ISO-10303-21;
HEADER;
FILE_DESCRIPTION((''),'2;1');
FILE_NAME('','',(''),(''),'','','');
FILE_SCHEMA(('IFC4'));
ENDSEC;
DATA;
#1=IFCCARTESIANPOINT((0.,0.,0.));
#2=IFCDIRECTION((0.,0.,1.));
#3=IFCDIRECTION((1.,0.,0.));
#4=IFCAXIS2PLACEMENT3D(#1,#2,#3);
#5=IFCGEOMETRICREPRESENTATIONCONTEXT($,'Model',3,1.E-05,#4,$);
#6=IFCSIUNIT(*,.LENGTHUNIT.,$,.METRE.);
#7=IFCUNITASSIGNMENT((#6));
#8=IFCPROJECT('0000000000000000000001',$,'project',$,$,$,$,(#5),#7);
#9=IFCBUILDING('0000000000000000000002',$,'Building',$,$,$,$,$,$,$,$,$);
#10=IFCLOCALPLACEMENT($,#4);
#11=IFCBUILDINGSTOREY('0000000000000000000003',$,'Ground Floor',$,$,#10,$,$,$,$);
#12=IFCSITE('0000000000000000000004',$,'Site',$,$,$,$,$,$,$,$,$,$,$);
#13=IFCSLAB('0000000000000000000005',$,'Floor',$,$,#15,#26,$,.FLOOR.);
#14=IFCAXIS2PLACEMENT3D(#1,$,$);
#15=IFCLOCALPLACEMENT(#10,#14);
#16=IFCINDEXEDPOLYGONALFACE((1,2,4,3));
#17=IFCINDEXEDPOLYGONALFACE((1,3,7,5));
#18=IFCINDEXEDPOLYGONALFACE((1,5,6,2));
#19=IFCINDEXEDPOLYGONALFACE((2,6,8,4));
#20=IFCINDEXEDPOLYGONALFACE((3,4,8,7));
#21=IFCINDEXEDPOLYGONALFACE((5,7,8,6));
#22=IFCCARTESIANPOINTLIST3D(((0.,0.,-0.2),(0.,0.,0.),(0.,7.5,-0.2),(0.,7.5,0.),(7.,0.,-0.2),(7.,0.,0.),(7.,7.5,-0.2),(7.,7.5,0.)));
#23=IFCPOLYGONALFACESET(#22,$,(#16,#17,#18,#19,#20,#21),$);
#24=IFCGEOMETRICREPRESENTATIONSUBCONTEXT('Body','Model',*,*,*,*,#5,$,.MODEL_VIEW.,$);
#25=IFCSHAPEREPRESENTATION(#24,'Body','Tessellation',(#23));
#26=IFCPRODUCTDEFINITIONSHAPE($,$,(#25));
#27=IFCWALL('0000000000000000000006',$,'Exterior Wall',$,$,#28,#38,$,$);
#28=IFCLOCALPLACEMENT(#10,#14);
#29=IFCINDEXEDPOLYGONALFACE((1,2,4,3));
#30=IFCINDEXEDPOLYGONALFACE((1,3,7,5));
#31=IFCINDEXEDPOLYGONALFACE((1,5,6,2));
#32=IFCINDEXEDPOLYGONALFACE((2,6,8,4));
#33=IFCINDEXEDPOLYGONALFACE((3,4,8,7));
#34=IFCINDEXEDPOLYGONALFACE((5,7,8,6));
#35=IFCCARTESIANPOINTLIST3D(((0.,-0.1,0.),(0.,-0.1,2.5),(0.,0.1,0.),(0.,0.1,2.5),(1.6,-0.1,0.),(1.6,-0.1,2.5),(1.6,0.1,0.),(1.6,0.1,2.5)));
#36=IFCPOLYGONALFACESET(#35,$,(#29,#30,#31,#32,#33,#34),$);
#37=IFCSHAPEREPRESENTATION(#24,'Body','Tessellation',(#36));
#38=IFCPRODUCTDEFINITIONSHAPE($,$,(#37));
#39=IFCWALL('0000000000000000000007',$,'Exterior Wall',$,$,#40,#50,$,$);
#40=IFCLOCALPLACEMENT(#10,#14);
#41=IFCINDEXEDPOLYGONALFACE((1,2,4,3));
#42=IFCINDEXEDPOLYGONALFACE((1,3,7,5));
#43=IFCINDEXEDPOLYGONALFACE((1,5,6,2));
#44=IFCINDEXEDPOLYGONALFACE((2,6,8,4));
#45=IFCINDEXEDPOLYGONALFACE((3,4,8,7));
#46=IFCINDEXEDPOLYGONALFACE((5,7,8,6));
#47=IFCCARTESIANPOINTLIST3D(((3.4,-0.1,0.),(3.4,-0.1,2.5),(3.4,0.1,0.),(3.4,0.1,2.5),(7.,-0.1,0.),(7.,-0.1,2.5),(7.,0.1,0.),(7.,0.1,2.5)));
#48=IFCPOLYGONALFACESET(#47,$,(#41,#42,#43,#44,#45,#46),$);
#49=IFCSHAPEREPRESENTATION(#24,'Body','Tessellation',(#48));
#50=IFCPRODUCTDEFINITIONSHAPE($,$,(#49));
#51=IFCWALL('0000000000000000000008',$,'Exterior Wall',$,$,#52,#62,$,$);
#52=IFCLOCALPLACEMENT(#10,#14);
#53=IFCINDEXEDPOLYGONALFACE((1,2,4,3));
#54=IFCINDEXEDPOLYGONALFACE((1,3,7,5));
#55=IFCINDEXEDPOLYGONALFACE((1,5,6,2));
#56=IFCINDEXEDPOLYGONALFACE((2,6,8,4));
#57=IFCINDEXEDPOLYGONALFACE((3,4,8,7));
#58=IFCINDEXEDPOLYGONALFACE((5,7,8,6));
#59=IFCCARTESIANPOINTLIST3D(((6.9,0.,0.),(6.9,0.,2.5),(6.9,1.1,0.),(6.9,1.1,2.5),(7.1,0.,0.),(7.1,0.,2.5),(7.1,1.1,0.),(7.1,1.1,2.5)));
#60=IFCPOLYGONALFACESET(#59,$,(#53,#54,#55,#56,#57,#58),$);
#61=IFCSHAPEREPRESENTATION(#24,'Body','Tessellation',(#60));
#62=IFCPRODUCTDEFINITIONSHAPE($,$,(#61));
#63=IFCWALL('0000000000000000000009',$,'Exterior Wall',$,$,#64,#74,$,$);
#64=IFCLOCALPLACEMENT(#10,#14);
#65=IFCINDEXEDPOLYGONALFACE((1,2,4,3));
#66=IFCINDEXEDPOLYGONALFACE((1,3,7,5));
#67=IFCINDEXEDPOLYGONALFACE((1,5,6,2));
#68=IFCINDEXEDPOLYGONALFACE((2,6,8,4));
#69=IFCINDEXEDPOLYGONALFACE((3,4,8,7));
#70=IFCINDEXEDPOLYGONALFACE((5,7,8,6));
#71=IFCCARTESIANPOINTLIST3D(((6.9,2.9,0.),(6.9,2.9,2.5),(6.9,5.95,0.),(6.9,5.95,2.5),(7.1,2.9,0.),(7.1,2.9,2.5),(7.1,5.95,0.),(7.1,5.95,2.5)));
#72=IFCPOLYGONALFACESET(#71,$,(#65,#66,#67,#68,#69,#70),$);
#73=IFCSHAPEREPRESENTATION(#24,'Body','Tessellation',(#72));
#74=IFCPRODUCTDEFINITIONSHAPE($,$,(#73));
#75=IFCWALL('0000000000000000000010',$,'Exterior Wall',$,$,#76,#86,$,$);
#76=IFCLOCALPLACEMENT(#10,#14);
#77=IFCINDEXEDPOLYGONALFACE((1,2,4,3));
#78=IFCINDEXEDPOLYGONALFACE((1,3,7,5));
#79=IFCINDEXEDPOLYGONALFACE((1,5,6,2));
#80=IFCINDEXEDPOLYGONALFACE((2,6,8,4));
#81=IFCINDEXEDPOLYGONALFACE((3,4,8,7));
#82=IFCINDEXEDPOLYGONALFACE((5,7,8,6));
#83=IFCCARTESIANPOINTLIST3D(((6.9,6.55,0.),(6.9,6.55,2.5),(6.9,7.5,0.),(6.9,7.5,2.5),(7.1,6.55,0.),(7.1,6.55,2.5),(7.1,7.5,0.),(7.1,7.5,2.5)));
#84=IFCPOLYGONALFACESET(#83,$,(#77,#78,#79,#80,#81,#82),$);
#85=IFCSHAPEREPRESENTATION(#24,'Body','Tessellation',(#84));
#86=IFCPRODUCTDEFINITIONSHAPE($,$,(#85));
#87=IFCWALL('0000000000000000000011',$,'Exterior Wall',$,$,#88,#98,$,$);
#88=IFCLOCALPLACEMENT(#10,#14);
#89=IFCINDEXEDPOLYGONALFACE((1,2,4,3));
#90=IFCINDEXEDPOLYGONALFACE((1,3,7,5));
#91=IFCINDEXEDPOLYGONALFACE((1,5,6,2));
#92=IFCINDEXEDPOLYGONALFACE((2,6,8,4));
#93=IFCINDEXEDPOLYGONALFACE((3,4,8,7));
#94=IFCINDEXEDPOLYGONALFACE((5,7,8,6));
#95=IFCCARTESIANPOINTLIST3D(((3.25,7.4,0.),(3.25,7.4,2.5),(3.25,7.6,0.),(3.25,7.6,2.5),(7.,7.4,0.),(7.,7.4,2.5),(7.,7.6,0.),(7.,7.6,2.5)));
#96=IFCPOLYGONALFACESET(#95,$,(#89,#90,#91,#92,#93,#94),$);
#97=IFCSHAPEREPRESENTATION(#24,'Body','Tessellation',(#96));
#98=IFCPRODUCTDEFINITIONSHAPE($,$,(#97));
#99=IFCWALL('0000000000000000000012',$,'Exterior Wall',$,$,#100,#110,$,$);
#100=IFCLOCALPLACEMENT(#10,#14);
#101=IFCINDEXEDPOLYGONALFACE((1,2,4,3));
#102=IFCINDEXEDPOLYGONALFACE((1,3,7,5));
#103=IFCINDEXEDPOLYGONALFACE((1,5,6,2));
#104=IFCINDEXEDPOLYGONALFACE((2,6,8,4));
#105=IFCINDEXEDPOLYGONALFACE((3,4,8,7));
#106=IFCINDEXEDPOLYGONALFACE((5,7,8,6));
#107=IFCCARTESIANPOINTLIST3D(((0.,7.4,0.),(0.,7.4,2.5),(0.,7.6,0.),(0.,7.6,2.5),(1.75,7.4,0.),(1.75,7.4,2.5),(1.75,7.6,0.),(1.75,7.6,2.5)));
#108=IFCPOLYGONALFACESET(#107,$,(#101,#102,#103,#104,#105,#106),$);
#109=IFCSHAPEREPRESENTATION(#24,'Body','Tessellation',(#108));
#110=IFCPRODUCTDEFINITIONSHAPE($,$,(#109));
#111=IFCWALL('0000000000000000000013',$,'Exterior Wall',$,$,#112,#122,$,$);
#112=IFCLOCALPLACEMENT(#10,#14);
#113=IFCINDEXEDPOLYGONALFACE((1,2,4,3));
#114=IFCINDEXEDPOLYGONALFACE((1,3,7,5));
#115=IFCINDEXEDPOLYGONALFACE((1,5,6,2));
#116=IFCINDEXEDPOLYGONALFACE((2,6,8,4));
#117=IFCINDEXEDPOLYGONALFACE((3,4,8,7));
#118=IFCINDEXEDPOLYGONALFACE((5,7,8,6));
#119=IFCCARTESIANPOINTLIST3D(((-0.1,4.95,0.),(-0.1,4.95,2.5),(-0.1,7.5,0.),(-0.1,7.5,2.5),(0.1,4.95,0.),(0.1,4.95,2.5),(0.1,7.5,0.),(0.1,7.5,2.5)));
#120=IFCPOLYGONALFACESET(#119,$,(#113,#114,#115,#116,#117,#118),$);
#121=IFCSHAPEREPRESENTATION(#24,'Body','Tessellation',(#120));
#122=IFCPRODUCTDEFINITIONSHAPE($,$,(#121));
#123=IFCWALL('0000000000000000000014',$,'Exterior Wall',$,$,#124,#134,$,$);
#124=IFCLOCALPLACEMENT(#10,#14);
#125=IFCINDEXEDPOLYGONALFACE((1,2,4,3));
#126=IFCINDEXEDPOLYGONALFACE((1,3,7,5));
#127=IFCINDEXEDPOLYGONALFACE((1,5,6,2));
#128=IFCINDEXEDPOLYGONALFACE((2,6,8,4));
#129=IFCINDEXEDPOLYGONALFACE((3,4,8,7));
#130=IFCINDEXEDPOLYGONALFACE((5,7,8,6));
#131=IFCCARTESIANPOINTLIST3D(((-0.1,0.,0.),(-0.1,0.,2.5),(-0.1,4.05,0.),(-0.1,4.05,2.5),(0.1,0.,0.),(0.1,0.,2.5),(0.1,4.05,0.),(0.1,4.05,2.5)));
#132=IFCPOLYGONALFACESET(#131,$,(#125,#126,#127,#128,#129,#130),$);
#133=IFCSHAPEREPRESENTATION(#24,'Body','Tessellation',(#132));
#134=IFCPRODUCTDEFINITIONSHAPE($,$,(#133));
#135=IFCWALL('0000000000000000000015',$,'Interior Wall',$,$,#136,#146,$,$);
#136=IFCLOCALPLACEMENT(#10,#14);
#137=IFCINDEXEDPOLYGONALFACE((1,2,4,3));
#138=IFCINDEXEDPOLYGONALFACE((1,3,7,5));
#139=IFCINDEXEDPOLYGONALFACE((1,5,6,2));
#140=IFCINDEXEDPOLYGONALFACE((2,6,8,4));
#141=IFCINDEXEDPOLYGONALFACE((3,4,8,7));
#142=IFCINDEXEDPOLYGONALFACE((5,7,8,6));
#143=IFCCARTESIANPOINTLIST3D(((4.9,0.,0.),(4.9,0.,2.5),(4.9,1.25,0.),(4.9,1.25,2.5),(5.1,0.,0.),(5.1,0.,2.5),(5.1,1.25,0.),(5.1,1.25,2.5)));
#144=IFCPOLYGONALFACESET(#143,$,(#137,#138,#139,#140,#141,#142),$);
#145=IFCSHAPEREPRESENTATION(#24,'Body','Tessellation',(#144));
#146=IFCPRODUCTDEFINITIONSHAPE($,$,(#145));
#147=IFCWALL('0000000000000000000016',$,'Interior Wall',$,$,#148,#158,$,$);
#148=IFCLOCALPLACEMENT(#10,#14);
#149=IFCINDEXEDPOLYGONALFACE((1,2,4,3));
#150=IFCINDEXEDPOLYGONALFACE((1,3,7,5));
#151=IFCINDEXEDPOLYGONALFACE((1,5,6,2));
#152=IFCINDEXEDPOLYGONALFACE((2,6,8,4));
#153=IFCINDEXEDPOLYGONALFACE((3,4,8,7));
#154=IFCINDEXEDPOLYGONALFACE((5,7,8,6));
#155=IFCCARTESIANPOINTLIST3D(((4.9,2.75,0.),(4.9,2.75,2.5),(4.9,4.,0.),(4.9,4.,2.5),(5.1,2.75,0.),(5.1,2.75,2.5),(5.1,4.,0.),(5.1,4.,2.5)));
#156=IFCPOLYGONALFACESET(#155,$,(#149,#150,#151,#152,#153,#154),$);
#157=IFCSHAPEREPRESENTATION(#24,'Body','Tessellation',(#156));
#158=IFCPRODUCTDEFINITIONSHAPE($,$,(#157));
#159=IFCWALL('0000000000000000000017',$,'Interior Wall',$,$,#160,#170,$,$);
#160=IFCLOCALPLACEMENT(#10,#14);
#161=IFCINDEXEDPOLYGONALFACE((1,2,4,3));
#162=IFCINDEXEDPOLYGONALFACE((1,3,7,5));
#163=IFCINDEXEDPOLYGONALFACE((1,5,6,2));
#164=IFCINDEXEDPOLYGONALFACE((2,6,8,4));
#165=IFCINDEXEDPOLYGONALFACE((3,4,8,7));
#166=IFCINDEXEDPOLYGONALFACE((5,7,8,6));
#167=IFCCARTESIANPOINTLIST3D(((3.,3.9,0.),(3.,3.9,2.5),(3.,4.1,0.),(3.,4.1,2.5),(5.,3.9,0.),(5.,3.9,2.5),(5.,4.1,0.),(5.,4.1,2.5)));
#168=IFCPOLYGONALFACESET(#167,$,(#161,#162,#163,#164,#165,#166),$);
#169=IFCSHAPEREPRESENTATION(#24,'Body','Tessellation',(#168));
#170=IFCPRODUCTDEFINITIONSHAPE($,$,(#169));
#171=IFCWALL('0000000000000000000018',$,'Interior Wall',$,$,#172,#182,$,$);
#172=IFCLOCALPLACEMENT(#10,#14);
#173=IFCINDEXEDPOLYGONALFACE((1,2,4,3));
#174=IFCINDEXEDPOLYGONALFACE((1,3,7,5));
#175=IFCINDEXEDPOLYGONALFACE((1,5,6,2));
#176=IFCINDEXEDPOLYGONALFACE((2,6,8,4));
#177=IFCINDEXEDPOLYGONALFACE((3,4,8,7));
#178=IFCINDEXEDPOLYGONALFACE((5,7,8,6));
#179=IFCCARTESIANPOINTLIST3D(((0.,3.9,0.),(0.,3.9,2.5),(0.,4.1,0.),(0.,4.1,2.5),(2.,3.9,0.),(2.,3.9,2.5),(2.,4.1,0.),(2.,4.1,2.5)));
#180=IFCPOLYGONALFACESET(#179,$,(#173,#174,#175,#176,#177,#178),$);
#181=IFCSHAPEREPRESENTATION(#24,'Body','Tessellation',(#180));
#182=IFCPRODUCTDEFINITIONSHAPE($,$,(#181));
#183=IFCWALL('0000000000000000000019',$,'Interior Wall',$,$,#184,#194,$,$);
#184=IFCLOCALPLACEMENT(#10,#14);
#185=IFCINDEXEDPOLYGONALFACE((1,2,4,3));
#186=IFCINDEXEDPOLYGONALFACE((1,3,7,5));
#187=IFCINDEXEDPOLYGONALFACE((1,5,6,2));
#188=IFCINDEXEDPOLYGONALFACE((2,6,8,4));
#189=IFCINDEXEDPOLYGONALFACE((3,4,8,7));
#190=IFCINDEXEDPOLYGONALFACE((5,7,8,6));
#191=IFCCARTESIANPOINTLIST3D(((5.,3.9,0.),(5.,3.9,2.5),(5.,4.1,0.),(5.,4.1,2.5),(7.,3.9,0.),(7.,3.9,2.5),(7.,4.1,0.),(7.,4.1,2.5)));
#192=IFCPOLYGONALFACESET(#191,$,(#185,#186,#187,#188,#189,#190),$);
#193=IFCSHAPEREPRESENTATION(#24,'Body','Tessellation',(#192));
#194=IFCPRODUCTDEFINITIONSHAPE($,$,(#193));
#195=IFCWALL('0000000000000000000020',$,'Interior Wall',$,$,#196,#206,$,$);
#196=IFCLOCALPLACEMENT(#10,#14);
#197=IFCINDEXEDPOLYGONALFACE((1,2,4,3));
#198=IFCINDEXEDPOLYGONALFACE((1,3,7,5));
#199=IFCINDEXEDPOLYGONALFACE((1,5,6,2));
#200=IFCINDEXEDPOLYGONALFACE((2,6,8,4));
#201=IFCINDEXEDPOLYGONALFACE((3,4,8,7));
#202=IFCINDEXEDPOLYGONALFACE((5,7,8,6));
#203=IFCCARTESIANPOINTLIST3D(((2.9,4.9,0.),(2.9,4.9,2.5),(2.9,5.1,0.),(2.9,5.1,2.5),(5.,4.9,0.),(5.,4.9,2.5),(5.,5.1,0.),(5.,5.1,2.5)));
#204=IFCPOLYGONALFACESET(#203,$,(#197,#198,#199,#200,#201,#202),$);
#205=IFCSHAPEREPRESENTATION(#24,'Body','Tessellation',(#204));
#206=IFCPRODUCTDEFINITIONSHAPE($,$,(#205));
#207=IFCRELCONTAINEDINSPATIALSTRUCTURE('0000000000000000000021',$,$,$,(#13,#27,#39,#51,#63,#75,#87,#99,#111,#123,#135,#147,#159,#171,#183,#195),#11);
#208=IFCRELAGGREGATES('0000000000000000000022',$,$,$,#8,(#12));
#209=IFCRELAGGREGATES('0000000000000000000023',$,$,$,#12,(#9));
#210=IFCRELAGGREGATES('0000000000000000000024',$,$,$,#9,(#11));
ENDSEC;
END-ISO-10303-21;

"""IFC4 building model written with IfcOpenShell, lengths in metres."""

from ifc_helpers import new_model, si_unit, frame, origin_with_axes, place, context, subcontext, project, spatial, indexed_curve, outline, extrude, element, save


model = new_model("IFC4")

# Units and contexts
model_context = context("Model", 3, precision=1e-05, world=origin_with_axes())
body_context = subcontext(model_context, "Body", "Model", "MODEL_VIEW")
ifc_project = project(units=[si_unit("LENGTHUNIT", "METRE")], contexts=[model_context])

# Site, building, storey
site = spatial("IfcSite", under=ifc_project, Name="Site")
building = spatial("IfcBuilding", under=site, Name="Building")
storey_placement = place(None, origin_with_axes())
storey = spatial("IfcBuildingStorey", under=building, at=storey_placement, Name="Ground Floor")

# Slab
slab_placement = place(storey_placement, frame((0.0, 0.0, -0.2), z_axis=(0.0, 0.0, 1.0), x_axis=(1.0, 0.0, 0.0)))
element("IfcSlab", 1, at=slab_placement, inside=storey, Name="Floor", PredefinedType="FLOOR", context=body_context, shape_type="SweptSolid", body=[
    extrude(outline(indexed_curve([(0.0, 0.0), (7.0, 0.0), (7.0, 7.5), (0.0, 7.5)])), None, (0.0, 0.0, 1.0), 0.2),
])

# Walls
wall_1_placement = place(storey_placement, origin_with_axes())
element("IfcWall", 2, at=wall_1_placement, inside=storey, Name="Exterior Wall", context=body_context, shape_type="SweptSolid", body=[
    extrude(outline(indexed_curve([(0.0, 0.0), (0.0, 0.2), (1.6, 0.2), (1.6, 0.0), (0.0, 0.0)], self_intersect=False)), frame((0.0, -0.1, 0.0), z_axis=(0.0, 0.0, 1.0), x_axis=(1.0, 0.0, 0.0)), (0.0, 0.0, 1.0), 2.5),
])
wall_2_placement = place(storey_placement, frame((3.4, 0.0, 0.0), z_axis=(0.0, 0.0, 1.0), x_axis=(1.0, 0.0, 0.0)))
element("IfcWall", 3, at=wall_2_placement, inside=storey, Name="Exterior Wall", context=body_context, shape_type="SweptSolid", body=[
    extrude(outline(indexed_curve([(0.0, 0.0), (0.0, 0.2), (3.6, 0.2), (3.6, 0.0), (0.0, 0.0)], self_intersect=False)), frame((0.0, -0.1, 0.0), z_axis=(0.0, 0.0, 1.0), x_axis=(1.0, 0.0, 0.0)), (0.0, 0.0, 1.0), 2.5),
])
wall_3_placement = place(storey_placement, frame((7.0, 0.0, 0.0), z_axis=(0.0, 0.0, 1.0), x_axis=(0.0, 1.0, 0.0)))
element("IfcWall", 4, at=wall_3_placement, inside=storey, Name="Exterior Wall", context=body_context, shape_type="SweptSolid", body=[
    extrude(outline(indexed_curve([(0.0, 0.0), (0.0, 0.2), (1.1, 0.2), (1.1, 0.0), (0.0, 0.0)], self_intersect=False)), frame((0.0, -0.1, 0.0), z_axis=(0.0, 0.0, 1.0), x_axis=(1.0, 0.0, 0.0)), (0.0, 0.0, 1.0), 2.5),
])
wall_4_placement = place(storey_placement, frame((7.0, 2.9, 0.0), z_axis=(0.0, 0.0, 1.0), x_axis=(0.0, 1.0, 0.0)))
element("IfcWall", 5, at=wall_4_placement, inside=storey, Name="Exterior Wall", context=body_context, shape_type="SweptSolid", body=[
    extrude(outline(indexed_curve([(0.0, 0.0), (0.0, 0.2), (3.05, 0.2), (3.05, 0.0), (0.0, 0.0)], self_intersect=False)), frame((0.0, -0.1, 0.0), z_axis=(0.0, 0.0, 1.0), x_axis=(1.0, 0.0, 0.0)), (0.0, 0.0, 1.0), 2.5),
])
wall_5_placement = place(storey_placement, frame((7.0, 6.55, 0.0), z_axis=(0.0, 0.0, 1.0), x_axis=(0.0, 1.0, 0.0)))
element("IfcWall", 6, at=wall_5_placement, inside=storey, Name="Exterior Wall", context=body_context, shape_type="SweptSolid", body=[
    extrude(outline(indexed_curve([(0.0, 0.0), (0.0, 0.2), (0.95, 0.2), (0.95, 0.0), (0.0, 0.0)], self_intersect=False)), frame((0.0, -0.1, 0.0), z_axis=(0.0, 0.0, 1.0), x_axis=(1.0, 0.0, 0.0)), (0.0, 0.0, 1.0), 2.5),
])
wall_6_placement = place(storey_placement, frame((7.0, 7.5, 0.0), z_axis=(0.0, 0.0, 1.0), x_axis=(-1.0, 0.0, 0.0)))
element("IfcWall", 7, at=wall_6_placement, inside=storey, Name="Exterior Wall", context=body_context, shape_type="SweptSolid", body=[
    extrude(outline(indexed_curve([(0.0, 0.0), (0.0, 0.2), (3.75, 0.2), (3.75, 0.0), (0.0, 0.0)], self_intersect=False)), frame((0.0, -0.1, 0.0), z_axis=(0.0, 0.0, 1.0), x_axis=(1.0, 0.0, 0.0)), (0.0, 0.0, 1.0), 2.5),
])
wall_7_placement = place(storey_placement, frame((1.75, 7.5, 0.0), z_axis=(0.0, 0.0, 1.0), x_axis=(-1.0, 0.0, 0.0)))
element("IfcWall", 8, at=wall_7_placement, inside=storey, Name="Exterior Wall", context=body_context, shape_type="SweptSolid", body=[
    extrude(outline(indexed_curve([(0.0, 0.0), (0.0, 0.2), (1.75, 0.2), (1.75, 0.0), (0.0, 0.0)], self_intersect=False)), frame((0.0, -0.1, 0.0), z_axis=(0.0, 0.0, 1.0), x_axis=(1.0, 0.0, 0.0)), (0.0, 0.0, 1.0), 2.5),
])
wall_8_placement = place(storey_placement, frame((0.0, 7.5, 0.0), z_axis=(0.0, 0.0, 1.0), x_axis=(0.0, -1.0, 0.0)))
element("IfcWall", 9, at=wall_8_placement, inside=storey, Name="Exterior Wall", context=body_context, shape_type="SweptSolid", body=[
    extrude(outline(indexed_curve([(0.0, 0.0), (0.0, 0.2), (2.55, 0.2), (2.55, 0.0), (0.0, 0.0)], self_intersect=False)), frame((0.0, -0.1, 0.0), z_axis=(0.0, 0.0, 1.0), x_axis=(1.0, 0.0, 0.0)), (0.0, 0.0, 1.0), 2.5),
])
wall_9_placement = place(storey_placement, frame((0.0, 4.05, 0.0), z_axis=(0.0, 0.0, 1.0), x_axis=(0.0, -1.0, 0.0)))
element("IfcWall", 10, at=wall_9_placement, inside=storey, Name="Exterior Wall", context=body_context, shape_type="SweptSolid", body=[
    extrude(outline(indexed_curve([(0.0, 0.0), (0.0, 0.2), (4.05, 0.2), (4.05, 0.0), (0.0, 0.0)], self_intersect=False)), frame((0.0, -0.1, 0.0), z_axis=(0.0, 0.0, 1.0), x_axis=(1.0, 0.0, 0.0)), (0.0, 0.0, 1.0), 2.5),
])
for number, where, z_axis, x_axis, name in (
    (11, (5.0, 0.0, 0.0), (0.0, 0.0, 1.0), (0.0, 1.0, 0.0), "Interior Wall"),
    (12, (5.0, 2.75, 0.0), (0.0, 0.0, 1.0), (0.0, 1.0, 0.0), "Interior Wall"),
):
    element("IfcWall", number, at=place(storey_placement, frame(where, z_axis=z_axis, x_axis=x_axis)), inside=storey, Name=name, context=body_context, shape_type="SweptSolid", body=[
        extrude(outline(indexed_curve([(0.0, 0.0), (0.0, 0.2), (1.25, 0.2), (1.25, 0.0), (0.0, 0.0)], self_intersect=False)), frame((0.0, -0.1, 0.0), z_axis=(0.0, 0.0, 1.0), x_axis=(1.0, 0.0, 0.0)), (0.0, 0.0, 1.0), 2.5),
    ])
for number, where, z_axis, x_axis, name in (
    (13, (5.0, 4.0, 0.0), (0.0, 0.0, 1.0), (-1.0, 0.0, 0.0), "Interior Wall"),
    (14, (2.0, 4.0, 0.0), (0.0, 0.0, 1.0), (-1.0, 0.0, 0.0), "Interior Wall"),
    (15, (7.0, 4.0, 0.0), (0.0, 0.0, 1.0), (-1.0, 0.0, 0.0), "Interior Wall"),
):
    element("IfcWall", number, at=place(storey_placement, frame(where, z_axis=z_axis, x_axis=x_axis)), inside=storey, Name=name, context=body_context, shape_type="SweptSolid", body=[
        extrude(outline(indexed_curve([(0.0, 0.0), (0.0, 0.2), (2.0, 0.2), (2.0, 0.0), (0.0, 0.0)], self_intersect=False)), frame((0.0, -0.1, 0.0), z_axis=(0.0, 0.0, 1.0), x_axis=(1.0, 0.0, 0.0)), (0.0, 0.0, 1.0), 2.5),
    ])
for number, where, z_axis, x_axis, name in (
    (16, (5.0, 5.0, 0.0), (0.0, 0.0, 1.0), (-1.0, 0.0, 0.0), "Interior Wall"),
):
    element("IfcWall", number, at=place(storey_placement, frame(where, z_axis=z_axis, x_axis=x_axis)), inside=storey, Name=name, context=body_context, shape_type="SweptSolid", body=[
        extrude(outline(indexed_curve([(0.0, 0.0), (0.0, 0.2), (2.1, 0.2), (2.1, 0.0), (0.0, 0.0)], self_intersect=False)), frame((0.0, -0.1, 0.0), z_axis=(0.0, 0.0, 1.0), x_axis=(1.0, 0.0, 0.0)), (0.0, 0.0, 1.0), 2.5),
    ])

save(model, "model.ifc")
